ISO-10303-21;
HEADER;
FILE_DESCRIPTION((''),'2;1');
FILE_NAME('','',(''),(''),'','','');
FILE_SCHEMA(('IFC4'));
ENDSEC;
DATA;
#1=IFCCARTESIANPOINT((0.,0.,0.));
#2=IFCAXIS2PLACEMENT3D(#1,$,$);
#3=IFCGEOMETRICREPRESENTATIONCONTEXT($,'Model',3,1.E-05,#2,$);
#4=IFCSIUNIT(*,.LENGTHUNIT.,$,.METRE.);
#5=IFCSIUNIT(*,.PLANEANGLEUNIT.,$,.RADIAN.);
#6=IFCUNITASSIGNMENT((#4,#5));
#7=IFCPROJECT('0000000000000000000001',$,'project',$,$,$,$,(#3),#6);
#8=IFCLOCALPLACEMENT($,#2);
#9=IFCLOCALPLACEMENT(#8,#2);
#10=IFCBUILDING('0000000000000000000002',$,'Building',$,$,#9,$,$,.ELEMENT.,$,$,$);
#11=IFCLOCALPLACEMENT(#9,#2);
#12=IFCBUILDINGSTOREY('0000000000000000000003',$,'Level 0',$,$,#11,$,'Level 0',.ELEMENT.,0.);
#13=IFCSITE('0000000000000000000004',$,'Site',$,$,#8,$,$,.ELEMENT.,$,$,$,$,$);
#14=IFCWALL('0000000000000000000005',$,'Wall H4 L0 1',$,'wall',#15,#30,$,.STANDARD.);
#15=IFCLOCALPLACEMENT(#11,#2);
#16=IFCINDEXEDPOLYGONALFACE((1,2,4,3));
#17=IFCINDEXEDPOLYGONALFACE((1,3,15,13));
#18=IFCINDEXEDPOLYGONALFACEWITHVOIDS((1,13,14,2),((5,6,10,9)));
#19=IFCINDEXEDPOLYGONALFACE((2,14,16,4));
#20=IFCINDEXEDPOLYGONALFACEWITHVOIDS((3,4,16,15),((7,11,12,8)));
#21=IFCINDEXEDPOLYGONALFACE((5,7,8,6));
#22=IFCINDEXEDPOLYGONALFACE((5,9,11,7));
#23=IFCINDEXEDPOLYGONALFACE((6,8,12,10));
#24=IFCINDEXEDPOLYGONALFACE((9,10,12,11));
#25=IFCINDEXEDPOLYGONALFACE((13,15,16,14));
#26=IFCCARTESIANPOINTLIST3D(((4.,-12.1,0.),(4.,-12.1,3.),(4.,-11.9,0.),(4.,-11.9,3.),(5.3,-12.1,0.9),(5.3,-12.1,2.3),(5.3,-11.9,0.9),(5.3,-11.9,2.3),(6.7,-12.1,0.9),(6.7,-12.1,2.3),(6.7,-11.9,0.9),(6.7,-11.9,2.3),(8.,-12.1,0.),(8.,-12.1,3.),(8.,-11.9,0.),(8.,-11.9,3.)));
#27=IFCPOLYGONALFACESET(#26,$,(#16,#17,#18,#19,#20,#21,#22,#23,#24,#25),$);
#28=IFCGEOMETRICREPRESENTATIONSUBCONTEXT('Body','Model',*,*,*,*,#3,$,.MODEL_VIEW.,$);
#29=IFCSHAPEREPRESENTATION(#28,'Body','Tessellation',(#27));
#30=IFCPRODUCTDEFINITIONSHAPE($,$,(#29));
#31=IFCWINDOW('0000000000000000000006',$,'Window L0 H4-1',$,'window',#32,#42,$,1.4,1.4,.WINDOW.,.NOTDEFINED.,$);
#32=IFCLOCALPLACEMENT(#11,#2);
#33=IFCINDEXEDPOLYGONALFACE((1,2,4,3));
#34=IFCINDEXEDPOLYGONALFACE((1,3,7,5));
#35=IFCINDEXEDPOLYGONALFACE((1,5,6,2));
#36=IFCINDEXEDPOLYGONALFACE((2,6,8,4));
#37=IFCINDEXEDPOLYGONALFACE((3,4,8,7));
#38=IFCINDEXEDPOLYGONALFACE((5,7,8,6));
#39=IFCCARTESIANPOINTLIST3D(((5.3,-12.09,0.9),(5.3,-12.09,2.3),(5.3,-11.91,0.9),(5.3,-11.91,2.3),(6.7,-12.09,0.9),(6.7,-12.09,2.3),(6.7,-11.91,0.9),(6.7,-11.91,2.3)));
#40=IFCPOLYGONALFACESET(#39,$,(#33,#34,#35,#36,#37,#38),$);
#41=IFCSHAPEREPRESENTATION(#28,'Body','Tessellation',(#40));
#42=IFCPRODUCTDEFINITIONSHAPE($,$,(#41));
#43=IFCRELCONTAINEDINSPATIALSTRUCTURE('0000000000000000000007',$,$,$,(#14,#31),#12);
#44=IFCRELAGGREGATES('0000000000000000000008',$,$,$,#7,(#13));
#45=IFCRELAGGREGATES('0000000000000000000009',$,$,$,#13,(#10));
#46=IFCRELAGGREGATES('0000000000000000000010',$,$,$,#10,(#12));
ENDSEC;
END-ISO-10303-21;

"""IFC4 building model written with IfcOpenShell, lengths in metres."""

from ifc_helpers import new_model, si_unit, frame, frame_2d, origin, origin_2d, place, context, subcontext, project, spatial, rectangle, extrude, element, fill, save


model = new_model("IFC4")

# Units and contexts
model_context = context("Model", 3, precision=1e-05, world=origin())
body_context = subcontext(model_context, "Body", "Model", "MODEL_VIEW")
ifc_project = project(units=[si_unit("LENGTHUNIT", "METRE"), si_unit("PLANEANGLEUNIT", "RADIAN")], contexts=[model_context])

# Site, building, storey
site_placement = place(None, origin())
site = spatial("IfcSite", under=ifc_project, at=site_placement, Name="Site", CompositionType="ELEMENT")
building_placement = place(site_placement, origin())
building = spatial("IfcBuilding", under=site, at=building_placement, Name="Building", CompositionType="ELEMENT")
storey_placement = place(building_placement, origin())
storey = spatial("IfcBuildingStorey", under=building, at=storey_placement, Name="Level 0", LongName="Level 0", CompositionType="ELEMENT", Elevation=0.0)

# Wall, opening, window
wall_1_placement = place(storey_placement, frame((4.0, -12.0, 0.0), z_axis=(0.0, 0.0, 1.0), x_axis=(1.0, 0.0, 0.0)))
wall_1 = element("IfcWall", 1, at=wall_1_placement, inside=storey, Name="Wall H4 L0 1", ObjectType="wall", PredefinedType="STANDARD", context=body_context, shape_type="SweptSolid", body=[
    extrude(rectangle(XDim=4.0, YDim=0.2, at=frame_2d((2.0, 0.0))), origin(), (0.0, 0.0, 1.0), 3.0),
])
opening_1_placement = place(storey_placement, frame((6.0, -12.0, 0.9), z_axis=(0.0, 0.0, 1.0), x_axis=(1.0, 0.0, 0.0)))
opening_1 = element("IfcOpeningElement", 2, at=opening_1_placement, cuts=wall_1, ObjectType="Opening", PredefinedType="OPENING", context=body_context, shape_type="SweptSolid", body=[
    extrude(rectangle(XDim=1.4, YDim=0.22, at=origin_2d()), origin(), (0.0, 0.0, 1.0), 1.4),
])
window_1_placement = place(storey_placement, frame((6.0, -12.0, 0.9), z_axis=(0.0, 0.0, 1.0), x_axis=(1.0, 0.0, 0.0)))
window_1 = element("IfcWindow", 3, at=window_1_placement, inside=storey, Name="Window L0 H4-1", ObjectType="window", OverallHeight=1.4, OverallWidth=1.4, PartitioningType="NOTDEFINED", PredefinedType="WINDOW", context=body_context, shape_type="SweptSolid", body=[
    extrude(rectangle(XDim=1.4, YDim=0.18, at=origin_2d()), origin(), (0.0, 0.0, 1.0), 1.4),
])
fill(opening_1, window_1)

save(model, "model.ifc")
